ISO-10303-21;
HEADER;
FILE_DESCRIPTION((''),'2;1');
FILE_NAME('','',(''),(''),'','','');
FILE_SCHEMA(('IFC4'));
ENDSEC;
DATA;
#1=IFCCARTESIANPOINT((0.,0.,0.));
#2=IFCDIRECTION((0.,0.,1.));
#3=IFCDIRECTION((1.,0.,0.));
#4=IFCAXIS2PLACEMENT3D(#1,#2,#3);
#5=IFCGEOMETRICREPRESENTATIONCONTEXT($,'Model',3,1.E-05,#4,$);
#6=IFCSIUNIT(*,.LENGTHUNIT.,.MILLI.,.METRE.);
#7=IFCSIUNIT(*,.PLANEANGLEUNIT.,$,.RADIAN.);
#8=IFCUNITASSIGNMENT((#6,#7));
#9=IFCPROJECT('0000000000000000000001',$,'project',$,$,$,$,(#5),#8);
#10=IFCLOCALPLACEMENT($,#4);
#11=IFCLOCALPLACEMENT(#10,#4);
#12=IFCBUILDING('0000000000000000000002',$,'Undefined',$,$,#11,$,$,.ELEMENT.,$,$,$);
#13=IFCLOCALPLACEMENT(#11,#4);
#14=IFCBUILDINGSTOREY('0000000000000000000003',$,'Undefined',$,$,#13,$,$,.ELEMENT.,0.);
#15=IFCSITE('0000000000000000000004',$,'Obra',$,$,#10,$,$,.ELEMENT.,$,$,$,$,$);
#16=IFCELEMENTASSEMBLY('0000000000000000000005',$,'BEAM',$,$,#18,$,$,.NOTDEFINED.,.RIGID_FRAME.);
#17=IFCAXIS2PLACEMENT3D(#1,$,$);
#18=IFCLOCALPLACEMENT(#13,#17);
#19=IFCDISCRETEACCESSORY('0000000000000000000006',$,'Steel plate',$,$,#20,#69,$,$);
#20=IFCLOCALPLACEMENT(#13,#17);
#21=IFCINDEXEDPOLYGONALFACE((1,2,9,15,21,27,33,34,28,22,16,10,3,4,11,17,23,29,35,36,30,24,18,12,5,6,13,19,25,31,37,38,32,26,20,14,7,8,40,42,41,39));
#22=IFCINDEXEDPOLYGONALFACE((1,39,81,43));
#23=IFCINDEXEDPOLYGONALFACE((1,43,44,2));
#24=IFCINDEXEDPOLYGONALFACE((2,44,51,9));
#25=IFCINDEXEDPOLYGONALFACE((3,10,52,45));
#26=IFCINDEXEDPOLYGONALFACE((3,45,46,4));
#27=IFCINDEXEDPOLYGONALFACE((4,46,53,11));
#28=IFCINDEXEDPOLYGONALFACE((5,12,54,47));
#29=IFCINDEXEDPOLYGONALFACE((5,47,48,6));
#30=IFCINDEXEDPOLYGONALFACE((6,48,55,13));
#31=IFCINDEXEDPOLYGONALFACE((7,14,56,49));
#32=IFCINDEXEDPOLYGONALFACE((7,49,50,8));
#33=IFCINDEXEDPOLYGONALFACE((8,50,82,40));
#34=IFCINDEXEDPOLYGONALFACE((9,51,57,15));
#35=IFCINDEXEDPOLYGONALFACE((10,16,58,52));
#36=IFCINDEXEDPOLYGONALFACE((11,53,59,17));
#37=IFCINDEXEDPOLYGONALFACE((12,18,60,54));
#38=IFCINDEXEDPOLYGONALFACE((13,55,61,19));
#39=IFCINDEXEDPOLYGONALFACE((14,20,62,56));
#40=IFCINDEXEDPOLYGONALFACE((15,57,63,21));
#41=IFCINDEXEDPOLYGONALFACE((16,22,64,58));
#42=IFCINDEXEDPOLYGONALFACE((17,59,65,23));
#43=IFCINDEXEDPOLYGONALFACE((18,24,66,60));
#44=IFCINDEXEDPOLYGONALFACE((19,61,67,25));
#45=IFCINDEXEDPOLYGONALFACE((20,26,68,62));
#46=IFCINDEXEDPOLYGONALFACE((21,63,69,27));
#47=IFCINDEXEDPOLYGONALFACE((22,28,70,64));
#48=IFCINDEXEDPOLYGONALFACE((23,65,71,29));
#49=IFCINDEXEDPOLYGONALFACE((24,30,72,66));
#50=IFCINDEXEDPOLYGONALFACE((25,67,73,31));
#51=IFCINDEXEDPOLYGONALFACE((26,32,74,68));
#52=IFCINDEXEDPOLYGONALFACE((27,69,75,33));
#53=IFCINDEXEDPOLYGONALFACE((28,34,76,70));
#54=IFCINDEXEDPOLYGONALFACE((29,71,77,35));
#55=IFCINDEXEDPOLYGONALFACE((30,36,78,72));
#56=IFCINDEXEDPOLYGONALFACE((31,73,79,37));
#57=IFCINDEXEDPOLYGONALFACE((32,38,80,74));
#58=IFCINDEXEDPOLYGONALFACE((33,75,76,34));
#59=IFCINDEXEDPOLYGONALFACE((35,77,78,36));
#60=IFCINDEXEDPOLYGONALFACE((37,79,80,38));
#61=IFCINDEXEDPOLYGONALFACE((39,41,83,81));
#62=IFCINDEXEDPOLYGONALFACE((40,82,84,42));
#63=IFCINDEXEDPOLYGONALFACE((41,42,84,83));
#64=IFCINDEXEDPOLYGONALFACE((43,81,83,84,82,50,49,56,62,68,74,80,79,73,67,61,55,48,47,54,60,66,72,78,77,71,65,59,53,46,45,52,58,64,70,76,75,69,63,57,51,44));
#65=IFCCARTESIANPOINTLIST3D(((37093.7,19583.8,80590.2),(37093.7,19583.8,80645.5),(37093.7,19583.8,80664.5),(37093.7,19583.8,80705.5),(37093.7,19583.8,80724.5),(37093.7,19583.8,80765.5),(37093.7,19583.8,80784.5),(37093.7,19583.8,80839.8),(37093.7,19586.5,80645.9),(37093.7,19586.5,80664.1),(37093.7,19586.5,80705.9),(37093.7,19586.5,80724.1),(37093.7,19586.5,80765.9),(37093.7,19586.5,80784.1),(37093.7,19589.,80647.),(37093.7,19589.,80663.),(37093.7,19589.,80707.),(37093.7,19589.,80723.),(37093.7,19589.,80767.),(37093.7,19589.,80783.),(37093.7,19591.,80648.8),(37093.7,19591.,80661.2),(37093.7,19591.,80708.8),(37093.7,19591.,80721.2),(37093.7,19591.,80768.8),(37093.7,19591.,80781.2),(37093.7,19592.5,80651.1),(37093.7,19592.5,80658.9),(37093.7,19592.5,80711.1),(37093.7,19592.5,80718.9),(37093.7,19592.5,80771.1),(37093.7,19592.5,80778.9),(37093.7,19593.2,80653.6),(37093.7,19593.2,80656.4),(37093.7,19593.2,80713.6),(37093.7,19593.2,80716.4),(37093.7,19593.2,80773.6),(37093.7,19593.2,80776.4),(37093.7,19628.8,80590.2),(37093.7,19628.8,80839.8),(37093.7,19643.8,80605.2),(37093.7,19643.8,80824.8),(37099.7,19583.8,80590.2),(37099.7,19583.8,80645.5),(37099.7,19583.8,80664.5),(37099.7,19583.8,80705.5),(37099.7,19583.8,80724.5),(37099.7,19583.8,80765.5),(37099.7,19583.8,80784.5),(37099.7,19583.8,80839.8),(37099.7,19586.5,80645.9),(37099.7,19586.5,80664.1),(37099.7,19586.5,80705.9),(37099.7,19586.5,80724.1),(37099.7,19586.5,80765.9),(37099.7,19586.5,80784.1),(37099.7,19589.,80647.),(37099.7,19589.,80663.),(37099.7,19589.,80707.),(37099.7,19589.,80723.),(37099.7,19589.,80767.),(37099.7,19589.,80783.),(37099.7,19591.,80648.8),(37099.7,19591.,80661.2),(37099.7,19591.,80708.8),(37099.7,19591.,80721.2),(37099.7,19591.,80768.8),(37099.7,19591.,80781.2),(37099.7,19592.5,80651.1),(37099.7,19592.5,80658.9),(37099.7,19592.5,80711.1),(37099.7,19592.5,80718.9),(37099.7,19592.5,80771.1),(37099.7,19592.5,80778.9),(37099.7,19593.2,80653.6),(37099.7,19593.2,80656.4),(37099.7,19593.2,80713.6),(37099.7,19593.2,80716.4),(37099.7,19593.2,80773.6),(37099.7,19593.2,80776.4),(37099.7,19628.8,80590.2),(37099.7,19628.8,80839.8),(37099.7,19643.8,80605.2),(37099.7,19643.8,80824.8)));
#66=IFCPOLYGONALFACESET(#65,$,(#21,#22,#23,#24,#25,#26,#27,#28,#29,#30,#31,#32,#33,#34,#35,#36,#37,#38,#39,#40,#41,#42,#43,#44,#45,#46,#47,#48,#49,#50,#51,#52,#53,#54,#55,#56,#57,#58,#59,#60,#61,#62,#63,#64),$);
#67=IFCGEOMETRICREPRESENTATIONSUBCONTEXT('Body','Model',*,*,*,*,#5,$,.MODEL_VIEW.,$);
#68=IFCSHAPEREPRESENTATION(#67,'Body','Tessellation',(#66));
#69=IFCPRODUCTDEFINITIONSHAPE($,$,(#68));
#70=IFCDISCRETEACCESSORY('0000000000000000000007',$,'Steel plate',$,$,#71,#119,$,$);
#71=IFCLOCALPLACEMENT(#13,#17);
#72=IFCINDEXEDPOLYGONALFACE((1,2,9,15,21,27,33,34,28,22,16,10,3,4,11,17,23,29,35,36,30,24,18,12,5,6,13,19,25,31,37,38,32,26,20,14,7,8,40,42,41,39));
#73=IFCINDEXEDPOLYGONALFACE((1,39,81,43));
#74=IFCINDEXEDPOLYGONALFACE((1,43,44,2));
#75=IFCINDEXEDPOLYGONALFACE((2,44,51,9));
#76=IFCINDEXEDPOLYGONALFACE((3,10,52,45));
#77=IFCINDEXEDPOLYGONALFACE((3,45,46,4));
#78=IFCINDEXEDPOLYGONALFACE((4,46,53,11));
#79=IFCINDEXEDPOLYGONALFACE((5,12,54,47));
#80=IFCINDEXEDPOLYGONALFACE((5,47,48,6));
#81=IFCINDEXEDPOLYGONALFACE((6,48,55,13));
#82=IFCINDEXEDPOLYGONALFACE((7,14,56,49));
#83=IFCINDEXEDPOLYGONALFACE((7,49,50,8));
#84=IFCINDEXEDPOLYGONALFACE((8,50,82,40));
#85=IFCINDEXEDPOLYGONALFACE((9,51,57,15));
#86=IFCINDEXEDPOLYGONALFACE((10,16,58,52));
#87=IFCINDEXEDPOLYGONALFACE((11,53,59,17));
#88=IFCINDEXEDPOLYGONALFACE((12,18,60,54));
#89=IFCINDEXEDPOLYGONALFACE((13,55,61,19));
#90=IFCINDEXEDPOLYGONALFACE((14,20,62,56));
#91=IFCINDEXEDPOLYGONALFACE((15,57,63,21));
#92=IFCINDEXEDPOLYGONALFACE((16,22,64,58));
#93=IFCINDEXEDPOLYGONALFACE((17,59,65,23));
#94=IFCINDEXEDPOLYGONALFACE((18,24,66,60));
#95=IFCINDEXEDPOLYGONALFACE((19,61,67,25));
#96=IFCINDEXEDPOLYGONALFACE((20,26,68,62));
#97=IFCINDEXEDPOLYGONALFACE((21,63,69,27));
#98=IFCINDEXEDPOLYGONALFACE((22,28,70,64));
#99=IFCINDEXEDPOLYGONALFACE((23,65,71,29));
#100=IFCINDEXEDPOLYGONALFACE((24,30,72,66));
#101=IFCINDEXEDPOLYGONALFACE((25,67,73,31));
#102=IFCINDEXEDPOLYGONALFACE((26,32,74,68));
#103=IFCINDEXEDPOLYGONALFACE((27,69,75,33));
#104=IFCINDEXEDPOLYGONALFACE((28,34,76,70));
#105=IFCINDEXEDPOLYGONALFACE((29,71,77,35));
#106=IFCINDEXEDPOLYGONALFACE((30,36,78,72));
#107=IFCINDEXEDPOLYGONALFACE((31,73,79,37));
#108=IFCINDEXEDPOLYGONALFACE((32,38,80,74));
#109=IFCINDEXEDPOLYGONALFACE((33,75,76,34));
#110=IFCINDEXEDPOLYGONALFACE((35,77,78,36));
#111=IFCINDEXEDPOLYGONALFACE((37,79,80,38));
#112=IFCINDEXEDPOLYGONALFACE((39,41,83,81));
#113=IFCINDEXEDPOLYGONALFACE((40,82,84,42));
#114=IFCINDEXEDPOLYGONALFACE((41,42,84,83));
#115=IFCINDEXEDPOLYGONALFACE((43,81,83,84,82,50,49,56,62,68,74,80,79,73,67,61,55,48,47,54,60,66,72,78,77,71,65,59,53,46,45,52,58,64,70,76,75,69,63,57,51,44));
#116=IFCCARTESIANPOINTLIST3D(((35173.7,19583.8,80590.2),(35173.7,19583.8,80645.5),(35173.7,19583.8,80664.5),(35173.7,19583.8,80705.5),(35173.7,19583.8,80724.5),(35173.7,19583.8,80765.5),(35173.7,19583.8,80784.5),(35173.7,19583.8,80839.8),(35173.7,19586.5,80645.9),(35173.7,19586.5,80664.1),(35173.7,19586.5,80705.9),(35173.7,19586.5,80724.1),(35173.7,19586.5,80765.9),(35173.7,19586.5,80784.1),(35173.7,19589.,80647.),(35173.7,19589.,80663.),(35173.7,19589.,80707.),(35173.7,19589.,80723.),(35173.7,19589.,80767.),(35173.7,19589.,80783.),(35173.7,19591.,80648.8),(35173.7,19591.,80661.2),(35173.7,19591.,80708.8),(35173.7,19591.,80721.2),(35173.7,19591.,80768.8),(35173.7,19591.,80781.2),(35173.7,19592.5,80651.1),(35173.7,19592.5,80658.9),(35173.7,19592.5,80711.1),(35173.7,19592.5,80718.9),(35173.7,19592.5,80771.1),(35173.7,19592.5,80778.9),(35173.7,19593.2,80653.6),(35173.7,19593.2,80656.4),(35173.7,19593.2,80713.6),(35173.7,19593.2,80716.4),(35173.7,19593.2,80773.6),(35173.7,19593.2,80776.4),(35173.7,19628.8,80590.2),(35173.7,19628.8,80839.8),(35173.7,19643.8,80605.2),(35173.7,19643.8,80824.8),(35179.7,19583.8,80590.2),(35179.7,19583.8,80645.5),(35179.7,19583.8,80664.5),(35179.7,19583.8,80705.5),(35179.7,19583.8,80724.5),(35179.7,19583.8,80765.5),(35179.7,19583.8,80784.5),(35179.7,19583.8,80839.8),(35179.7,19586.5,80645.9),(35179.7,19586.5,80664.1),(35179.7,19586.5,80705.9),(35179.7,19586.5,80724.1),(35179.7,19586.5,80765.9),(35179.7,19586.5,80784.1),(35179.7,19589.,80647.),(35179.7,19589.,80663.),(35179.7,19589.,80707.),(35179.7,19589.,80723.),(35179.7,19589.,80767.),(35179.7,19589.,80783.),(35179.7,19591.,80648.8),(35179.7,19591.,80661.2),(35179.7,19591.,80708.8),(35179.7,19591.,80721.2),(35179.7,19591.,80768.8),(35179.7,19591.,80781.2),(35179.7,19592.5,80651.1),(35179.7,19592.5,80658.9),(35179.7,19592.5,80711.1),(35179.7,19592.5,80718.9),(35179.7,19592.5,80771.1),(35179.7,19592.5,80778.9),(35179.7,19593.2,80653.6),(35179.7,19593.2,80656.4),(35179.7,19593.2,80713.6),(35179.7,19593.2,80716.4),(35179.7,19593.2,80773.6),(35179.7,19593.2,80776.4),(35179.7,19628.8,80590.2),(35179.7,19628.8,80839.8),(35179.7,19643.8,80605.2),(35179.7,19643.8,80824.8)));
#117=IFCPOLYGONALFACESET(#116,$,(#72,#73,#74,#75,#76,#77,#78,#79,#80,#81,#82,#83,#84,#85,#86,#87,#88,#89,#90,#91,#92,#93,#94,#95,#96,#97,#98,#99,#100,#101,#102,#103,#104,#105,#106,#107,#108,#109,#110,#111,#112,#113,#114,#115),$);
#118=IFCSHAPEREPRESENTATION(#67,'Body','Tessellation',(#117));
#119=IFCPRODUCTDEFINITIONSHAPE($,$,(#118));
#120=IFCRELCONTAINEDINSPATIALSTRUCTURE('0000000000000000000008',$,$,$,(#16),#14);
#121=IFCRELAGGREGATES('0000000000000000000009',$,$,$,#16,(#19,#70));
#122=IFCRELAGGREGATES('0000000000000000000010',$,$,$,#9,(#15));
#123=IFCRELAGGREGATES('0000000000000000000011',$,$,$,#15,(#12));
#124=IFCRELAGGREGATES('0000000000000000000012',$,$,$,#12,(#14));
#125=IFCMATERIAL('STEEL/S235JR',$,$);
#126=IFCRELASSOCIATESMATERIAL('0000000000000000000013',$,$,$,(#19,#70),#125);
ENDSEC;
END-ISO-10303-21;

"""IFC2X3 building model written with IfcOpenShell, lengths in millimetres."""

from ifc_helpers import new_model, si_unit, frame, origin_with_axes, origin_2d_with_axis, place, context, subcontext, project, spatial, polyline, circle, outline, extrude, source, transform, mapped, material, element, aggregate, save


model = new_model("IFC2X3")

# Units and contexts
model_context = context("Model", 3, precision=1e-05, world=origin_with_axes())
body_context = subcontext(model_context, "Body", "Model", "MODEL_VIEW")
ifc_project = project(units=[si_unit("LENGTHUNIT", "METRE", prefix="MILLI"), si_unit("PLANEANGLEUNIT", "RADIAN")], contexts=[model_context])

# Site, building, storey
site_placement = place(None, origin_with_axes())
site = spatial("IfcSite", under=ifc_project, at=site_placement, Name="Obra", CompositionType="ELEMENT")
building_placement = place(site_placement, origin_with_axes())
building = spatial("IfcBuilding", under=site, at=building_placement, Name="Undefined", CompositionType="ELEMENT")
storey_placement = place(building_placement, origin_with_axes())
storey = spatial("IfcBuildingStorey", under=building, at=storey_placement, Name="Undefined", CompositionType="ELEMENT", Elevation=0.0)

# Shared definitions
ifc_material_1 = material(Name="STEEL/S235JR")

# Element assembly
assembly_1_placement = place(storey_placement, origin_with_axes())
assembly_1 = element("IfcElementAssembly", 1, at=assembly_1_placement, inside=storey, Name="BEAM", AssemblyPlace="NOTDEFINED", PredefinedType="RIGID_FRAME")
shared_shape_1 = source(origin_with_axes(), body_context, "Body", "SweptSolid", [
    extrude(circle(Radius=9.5, at=origin_2d_with_axis()), frame((0.0, -9.4, 0.0), z_axis=(0.0, 1.0, 0.0), x_axis=(1.0, 0.0, 0.0)), (0.0, 0.0, 1.0), 6.2),
])

# Discrete accessories, openings
discrete_accessory_1_placement = place(assembly_1_placement, frame((37096.7, 19583.8, 80590.2), z_axis=(1.0, 0.0, 0.0), x_axis=(0.0, 1.0, 0.0)))
discrete_accessory_1 = element("IfcDiscreteAccessory", 2, at=discrete_accessory_1_placement, material=ifc_material_1, Name="Steel plate", context=body_context, shape_type="SweptSolid", body=[
    extrude(outline(polyline([(0.0, 0.0), (45.0, 0.0), (60.0, 15.0), (60.0, 234.6), (45.0, 249.6), (0.0, 249.6), (0.0, 0.0)])), frame((0.0, 0.0, -3.0), z_axis=(0.0, 0.0, 1.0), x_axis=(1.0, 0.0, 0.0)), (0.0, 0.0, 1.0), 6.0),
])
opening_1_placement = place(assembly_1_placement, frame((37103.0, 19633.8, 80850.0), z_axis=(0.0, -1.0, 0.0), x_axis=(0.0, 0.0, -1.0)))
element("IfcOpeningElement", 3, at=opening_1_placement, cuts=discrete_accessory_1, ObjectType="Opening", context=body_context, shape_type="MappedRepresentation", body=[
    mapped(shared_shape_1, transform((75.0, 0.0, 50.0))),
    mapped(shared_shape_1, transform((135.0, 0.0, 50.0))),
    mapped(shared_shape_1, transform((195.0, 0.0, 50.0))),
])
discrete_accessory_2_placement = place(assembly_1_placement, frame((35176.7, 19583.8, 80590.2), z_axis=(1.0, 0.0, 0.0), x_axis=(0.0, 1.0, 0.0)))
discrete_accessory_2 = element("IfcDiscreteAccessory", 4, at=discrete_accessory_2_placement, material=ifc_material_1, Name="Steel plate", context=body_context, shape_type="SweptSolid", body=[
    extrude(outline(polyline([(0.0, 0.0), (45.0, 0.0), (60.0, 15.0), (60.0, 234.6), (45.0, 249.6), (0.0, 249.6), (0.0, 0.0)])), frame((0.0, 0.0, -3.0), z_axis=(0.0, 0.0, 1.0), x_axis=(1.0, 0.0, 0.0)), (0.0, 0.0, 1.0), 6.0),
])
opening_2_placement = place(assembly_1_placement, frame((35183.0, 19633.8, 80850.0), z_axis=(0.0, -1.0, 0.0), x_axis=(0.0, 0.0, -1.0)))
element("IfcOpeningElement", 5, at=opening_2_placement, cuts=discrete_accessory_2, ObjectType="Opening", context=body_context, shape_type="MappedRepresentation", body=[
    mapped(shared_shape_1, transform((75.0, 0.0, 50.0))),
    mapped(shared_shape_1, transform((135.0, 0.0, 50.0))),
    mapped(shared_shape_1, transform((195.0, 0.0, 50.0))),
])
aggregate(assembly_1, [discrete_accessory_1, discrete_accessory_2])

save(model, "model.ifc")
